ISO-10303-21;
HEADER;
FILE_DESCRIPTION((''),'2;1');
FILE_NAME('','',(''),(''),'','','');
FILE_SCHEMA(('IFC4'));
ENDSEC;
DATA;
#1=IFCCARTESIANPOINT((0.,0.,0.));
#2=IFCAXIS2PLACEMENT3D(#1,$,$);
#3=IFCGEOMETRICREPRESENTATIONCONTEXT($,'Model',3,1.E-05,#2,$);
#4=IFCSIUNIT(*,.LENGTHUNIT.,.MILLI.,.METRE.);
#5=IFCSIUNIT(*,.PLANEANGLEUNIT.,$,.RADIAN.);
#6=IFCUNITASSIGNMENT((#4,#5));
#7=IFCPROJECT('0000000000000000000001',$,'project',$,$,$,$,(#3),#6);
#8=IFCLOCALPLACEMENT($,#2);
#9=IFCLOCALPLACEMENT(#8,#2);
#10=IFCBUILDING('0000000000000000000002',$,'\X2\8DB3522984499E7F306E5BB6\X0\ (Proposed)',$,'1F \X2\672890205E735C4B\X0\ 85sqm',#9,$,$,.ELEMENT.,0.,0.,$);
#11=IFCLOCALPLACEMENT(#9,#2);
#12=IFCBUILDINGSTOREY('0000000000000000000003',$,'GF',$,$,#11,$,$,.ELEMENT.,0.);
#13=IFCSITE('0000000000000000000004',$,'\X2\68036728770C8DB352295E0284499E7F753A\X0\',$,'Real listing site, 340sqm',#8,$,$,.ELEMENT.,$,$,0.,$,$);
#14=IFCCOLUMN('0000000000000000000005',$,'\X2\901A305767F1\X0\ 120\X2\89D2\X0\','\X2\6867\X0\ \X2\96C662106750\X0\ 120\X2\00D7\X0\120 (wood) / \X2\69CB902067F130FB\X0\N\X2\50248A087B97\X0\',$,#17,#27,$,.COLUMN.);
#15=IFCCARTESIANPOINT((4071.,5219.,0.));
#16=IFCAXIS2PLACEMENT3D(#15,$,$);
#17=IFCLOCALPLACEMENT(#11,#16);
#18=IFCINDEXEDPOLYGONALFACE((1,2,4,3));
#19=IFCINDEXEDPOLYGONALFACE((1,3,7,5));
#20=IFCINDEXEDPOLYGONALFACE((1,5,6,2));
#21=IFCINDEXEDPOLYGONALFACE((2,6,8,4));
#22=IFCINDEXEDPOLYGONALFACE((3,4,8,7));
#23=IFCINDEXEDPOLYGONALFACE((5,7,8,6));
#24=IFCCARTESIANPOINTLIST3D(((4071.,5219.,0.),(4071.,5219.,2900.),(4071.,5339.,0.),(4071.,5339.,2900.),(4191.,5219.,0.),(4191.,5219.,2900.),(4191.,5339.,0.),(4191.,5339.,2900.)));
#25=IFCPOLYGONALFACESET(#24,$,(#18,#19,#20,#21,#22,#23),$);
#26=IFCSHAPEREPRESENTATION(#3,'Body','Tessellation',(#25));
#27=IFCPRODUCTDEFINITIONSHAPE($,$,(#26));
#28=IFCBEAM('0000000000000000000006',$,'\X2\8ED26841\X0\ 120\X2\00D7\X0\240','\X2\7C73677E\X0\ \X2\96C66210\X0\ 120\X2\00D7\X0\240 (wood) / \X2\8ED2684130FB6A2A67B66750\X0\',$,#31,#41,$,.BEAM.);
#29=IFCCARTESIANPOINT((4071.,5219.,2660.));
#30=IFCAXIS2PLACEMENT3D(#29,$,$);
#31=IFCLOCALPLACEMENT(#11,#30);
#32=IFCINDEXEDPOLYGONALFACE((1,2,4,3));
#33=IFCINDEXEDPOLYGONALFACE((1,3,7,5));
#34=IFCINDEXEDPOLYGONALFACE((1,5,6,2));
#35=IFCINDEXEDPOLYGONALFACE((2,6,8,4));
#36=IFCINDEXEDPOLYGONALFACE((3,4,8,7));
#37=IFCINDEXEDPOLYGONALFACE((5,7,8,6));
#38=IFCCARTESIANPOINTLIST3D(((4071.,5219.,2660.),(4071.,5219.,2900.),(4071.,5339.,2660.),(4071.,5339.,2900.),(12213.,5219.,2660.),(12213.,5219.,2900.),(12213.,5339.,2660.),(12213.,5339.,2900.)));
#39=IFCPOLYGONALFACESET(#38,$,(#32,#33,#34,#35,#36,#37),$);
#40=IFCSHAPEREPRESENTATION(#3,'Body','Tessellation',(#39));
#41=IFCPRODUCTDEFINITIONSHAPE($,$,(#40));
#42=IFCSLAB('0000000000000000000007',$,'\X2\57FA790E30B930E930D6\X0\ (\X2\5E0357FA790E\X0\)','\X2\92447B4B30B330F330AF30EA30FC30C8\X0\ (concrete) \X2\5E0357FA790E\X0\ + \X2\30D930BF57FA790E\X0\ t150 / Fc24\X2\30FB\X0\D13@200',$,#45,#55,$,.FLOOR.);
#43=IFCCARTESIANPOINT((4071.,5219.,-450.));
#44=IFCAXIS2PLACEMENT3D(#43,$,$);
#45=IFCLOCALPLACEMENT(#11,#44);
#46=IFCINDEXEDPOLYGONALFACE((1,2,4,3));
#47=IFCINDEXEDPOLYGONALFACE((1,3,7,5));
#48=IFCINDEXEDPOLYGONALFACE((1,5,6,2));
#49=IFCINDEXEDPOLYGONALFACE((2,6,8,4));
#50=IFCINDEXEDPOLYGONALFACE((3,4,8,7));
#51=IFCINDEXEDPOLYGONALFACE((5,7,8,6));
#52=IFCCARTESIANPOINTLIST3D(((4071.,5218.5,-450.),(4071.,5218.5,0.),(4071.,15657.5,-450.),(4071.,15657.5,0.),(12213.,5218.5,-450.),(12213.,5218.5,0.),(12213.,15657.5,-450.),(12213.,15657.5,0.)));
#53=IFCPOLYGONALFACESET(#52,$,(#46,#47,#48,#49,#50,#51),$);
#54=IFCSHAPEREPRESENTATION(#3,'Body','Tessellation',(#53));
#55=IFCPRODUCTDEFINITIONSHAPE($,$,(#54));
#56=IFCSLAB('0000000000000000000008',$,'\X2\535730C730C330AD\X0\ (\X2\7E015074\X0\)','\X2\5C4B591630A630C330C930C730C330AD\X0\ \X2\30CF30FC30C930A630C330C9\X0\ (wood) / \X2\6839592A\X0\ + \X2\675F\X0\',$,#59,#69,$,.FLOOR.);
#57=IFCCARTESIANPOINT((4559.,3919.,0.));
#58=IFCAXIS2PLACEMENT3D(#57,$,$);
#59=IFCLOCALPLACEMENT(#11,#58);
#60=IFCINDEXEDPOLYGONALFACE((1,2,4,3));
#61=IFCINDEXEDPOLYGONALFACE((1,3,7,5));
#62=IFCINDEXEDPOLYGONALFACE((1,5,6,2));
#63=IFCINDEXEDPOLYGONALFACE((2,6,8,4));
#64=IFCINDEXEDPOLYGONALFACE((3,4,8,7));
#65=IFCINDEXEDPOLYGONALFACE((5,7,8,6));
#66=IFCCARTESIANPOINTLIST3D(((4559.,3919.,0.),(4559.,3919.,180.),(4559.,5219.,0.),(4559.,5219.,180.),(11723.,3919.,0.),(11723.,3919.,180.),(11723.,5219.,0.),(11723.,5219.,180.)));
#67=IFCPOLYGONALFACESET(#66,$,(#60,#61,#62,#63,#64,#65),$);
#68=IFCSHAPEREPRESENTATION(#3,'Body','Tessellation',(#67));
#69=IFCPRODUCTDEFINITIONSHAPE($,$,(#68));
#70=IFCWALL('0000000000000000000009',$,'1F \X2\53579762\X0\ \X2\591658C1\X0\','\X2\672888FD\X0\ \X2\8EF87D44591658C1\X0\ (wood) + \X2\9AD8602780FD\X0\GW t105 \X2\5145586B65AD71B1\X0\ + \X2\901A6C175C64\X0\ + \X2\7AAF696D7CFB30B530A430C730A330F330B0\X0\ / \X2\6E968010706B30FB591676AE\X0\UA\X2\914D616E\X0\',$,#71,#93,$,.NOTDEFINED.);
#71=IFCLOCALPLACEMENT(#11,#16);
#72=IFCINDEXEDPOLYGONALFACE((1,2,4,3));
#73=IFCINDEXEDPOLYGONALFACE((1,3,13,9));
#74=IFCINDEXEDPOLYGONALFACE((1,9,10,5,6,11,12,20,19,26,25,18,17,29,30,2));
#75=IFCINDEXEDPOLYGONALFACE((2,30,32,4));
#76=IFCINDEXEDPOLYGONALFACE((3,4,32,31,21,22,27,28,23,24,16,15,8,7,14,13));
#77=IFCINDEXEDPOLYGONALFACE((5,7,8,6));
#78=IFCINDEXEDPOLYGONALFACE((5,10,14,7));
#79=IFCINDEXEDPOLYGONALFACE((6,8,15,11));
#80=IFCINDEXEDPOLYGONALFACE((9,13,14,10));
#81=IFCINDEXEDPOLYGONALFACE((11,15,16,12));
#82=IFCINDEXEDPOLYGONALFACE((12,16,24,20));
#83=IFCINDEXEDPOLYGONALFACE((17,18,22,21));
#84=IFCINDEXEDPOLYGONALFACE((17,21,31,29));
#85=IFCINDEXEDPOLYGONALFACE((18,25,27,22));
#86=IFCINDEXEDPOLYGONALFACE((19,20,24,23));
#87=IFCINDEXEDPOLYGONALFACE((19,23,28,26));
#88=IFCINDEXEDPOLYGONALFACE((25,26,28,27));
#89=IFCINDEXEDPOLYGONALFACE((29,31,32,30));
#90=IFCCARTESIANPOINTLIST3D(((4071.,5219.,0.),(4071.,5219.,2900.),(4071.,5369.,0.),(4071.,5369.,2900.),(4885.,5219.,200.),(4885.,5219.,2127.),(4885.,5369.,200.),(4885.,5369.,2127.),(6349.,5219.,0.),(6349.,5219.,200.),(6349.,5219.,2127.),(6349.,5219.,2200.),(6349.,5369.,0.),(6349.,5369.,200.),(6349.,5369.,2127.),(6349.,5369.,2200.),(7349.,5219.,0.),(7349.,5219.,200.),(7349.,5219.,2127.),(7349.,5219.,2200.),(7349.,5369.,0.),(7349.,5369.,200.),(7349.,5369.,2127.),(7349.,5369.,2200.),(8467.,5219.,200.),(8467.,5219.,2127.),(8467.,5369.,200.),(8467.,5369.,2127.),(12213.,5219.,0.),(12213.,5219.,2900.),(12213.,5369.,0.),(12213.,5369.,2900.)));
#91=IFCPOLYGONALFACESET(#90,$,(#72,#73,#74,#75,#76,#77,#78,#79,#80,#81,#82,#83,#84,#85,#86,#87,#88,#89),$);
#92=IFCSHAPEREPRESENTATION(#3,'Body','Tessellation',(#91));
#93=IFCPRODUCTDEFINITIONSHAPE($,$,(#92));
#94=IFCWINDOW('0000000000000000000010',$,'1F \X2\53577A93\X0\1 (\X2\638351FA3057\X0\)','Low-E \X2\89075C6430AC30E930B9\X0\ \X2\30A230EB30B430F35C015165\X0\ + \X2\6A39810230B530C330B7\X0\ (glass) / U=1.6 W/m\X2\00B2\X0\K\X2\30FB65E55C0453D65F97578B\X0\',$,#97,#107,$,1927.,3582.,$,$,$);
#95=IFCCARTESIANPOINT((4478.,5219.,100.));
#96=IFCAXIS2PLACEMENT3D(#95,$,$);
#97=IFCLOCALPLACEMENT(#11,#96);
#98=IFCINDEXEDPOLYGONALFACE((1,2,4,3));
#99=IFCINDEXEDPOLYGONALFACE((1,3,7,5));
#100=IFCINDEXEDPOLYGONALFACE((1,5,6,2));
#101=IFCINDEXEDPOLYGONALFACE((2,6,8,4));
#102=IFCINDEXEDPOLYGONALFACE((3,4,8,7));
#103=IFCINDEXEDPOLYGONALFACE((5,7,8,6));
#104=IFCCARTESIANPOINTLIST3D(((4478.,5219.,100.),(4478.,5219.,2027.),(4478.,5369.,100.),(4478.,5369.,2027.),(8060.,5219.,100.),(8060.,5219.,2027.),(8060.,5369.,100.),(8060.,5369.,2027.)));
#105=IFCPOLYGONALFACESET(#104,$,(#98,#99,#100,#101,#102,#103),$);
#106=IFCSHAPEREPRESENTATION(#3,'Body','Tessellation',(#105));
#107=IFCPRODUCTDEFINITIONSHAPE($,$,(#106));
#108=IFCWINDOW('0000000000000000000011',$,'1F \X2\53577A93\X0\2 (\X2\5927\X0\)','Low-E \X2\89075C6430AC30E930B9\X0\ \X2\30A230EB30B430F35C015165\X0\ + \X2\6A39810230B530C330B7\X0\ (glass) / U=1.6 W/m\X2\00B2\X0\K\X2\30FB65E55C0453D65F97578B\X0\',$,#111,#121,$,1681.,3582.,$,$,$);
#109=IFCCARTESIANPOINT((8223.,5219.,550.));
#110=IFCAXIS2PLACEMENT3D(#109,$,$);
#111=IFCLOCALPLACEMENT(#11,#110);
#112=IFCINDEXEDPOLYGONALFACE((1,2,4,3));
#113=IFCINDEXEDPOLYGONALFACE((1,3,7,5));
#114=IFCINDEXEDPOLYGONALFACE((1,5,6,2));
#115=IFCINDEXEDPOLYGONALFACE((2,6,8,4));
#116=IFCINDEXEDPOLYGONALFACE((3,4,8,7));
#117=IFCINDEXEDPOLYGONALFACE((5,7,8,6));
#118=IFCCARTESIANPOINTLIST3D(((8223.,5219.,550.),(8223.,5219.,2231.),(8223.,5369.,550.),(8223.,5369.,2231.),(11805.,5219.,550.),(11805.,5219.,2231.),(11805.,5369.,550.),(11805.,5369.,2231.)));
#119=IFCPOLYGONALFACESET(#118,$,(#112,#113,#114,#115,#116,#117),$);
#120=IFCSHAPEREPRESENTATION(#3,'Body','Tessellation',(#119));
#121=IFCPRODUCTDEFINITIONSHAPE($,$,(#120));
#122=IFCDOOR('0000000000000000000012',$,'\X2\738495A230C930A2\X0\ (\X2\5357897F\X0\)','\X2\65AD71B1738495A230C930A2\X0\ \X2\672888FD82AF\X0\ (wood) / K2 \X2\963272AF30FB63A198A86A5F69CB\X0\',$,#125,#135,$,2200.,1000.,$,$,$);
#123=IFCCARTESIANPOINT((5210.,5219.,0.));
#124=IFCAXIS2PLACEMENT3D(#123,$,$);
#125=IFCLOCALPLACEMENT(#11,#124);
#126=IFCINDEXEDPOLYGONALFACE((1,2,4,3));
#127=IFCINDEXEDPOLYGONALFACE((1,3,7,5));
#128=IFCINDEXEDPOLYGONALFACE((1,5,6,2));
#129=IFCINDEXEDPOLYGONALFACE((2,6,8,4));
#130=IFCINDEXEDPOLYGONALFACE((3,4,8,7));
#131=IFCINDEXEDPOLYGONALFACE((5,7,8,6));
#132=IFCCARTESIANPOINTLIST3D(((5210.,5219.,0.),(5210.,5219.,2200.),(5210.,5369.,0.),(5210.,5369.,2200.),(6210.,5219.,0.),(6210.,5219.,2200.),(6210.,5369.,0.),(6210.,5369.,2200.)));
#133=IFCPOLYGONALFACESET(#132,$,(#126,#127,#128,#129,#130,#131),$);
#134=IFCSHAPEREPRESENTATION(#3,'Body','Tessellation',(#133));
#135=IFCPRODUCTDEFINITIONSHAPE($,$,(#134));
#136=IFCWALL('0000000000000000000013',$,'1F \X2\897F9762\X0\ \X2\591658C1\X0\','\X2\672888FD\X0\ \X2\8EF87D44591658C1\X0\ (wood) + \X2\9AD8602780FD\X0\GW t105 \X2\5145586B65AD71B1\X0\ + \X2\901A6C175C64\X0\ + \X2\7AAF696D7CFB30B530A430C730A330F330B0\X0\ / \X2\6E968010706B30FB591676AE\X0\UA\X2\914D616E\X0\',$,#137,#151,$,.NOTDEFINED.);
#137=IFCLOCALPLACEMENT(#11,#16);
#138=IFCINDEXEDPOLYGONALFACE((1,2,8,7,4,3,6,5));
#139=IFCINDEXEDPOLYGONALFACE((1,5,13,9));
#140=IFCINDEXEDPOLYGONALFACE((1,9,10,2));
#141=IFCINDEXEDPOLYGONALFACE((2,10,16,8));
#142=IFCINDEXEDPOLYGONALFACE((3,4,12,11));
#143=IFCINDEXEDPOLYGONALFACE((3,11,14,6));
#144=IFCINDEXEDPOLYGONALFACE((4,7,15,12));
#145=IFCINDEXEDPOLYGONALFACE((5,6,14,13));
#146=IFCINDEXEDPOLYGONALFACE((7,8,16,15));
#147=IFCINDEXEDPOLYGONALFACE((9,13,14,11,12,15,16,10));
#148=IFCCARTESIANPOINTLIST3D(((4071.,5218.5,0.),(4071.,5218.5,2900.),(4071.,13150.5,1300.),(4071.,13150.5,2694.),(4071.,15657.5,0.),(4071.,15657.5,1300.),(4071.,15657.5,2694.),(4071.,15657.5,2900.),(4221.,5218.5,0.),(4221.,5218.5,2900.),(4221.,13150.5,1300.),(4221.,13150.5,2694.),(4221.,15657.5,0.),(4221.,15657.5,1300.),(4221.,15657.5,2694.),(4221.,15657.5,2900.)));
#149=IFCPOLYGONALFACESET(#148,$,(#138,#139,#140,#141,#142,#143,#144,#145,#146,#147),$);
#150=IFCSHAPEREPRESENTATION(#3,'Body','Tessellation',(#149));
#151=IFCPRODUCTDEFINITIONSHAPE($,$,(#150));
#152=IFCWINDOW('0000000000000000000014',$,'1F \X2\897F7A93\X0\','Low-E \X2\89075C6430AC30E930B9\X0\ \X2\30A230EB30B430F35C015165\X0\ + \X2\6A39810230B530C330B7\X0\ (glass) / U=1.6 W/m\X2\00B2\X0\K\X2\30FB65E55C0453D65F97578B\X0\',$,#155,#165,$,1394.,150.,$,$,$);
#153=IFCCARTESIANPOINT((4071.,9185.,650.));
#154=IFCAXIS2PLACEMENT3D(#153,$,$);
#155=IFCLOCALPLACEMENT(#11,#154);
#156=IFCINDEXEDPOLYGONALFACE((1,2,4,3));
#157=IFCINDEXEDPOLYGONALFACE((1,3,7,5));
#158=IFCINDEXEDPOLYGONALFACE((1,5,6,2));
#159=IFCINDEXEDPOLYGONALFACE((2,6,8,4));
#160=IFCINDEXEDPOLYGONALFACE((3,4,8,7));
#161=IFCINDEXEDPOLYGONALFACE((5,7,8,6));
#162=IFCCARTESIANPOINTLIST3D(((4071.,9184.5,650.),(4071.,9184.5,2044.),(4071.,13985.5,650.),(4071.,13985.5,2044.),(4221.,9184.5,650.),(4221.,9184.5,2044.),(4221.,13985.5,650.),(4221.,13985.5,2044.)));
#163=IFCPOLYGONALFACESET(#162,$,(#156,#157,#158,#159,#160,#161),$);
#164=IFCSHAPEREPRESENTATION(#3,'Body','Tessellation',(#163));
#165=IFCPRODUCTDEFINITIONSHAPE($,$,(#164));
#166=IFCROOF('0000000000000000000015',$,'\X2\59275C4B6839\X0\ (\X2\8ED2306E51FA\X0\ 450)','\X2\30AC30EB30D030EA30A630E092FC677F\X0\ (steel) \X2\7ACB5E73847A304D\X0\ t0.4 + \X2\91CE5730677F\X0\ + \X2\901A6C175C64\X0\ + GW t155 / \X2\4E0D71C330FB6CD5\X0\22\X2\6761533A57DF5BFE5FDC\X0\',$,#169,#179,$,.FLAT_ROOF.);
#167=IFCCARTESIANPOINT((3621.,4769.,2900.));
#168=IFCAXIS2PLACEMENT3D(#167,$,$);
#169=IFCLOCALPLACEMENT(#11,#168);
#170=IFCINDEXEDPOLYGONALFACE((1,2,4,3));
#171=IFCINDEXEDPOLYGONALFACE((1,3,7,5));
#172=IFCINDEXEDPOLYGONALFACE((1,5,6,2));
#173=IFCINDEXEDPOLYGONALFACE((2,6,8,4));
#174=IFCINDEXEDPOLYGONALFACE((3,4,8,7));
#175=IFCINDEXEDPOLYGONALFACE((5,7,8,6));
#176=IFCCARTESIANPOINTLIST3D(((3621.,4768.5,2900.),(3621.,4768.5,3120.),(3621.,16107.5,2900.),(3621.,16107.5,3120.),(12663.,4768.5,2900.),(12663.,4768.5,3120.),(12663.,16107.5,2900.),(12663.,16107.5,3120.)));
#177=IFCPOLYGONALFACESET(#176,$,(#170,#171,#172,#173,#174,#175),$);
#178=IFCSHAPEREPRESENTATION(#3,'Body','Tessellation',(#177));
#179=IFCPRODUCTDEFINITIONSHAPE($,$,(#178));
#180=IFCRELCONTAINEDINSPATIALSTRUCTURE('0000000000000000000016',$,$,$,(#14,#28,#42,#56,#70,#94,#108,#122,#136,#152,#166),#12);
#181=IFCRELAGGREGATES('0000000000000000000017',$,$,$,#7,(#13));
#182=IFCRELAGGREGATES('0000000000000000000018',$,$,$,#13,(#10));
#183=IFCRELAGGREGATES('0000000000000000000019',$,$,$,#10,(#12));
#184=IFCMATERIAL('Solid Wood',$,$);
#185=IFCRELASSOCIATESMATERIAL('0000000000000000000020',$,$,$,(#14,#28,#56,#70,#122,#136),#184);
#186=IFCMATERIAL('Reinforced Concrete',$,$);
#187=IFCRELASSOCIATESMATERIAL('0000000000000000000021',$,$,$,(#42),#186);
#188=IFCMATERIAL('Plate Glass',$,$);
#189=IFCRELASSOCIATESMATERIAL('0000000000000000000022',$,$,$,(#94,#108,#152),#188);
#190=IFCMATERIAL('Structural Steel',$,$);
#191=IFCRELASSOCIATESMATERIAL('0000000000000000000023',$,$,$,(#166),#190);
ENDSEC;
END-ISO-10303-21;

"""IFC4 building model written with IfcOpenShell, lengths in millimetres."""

from ifc_helpers import new_model, si_unit, frame, frame_2d, origin, place, context, project, spatial, rectangle, extrude, material, element, fill, save


model = new_model("IFC4")

# Units and contexts
model_context = context("Model", 3, precision=1e-05, world=origin())
ifc_project = project(units=[si_unit("LENGTHUNIT", "METRE", prefix="MILLI"), si_unit("PLANEANGLEUNIT", "RADIAN")], contexts=[model_context])

# Site, building, storey
site_placement = place(None, origin())
site = spatial("IfcSite", under=ifc_project, at=site_placement, Name="栃木県足利市葉鹿町", ObjectType="Real listing site, 340sqm", CompositionType="ELEMENT", RefElevation=0.0)
building_placement = place(site_placement, origin())
building = spatial("IfcBuilding", under=site, at=building_placement, Name="足利葉鹿の家 (Proposed)", ObjectType="1F 木造平屋 85sqm", CompositionType="ELEMENT", ElevationOfRefHeight=0.0, ElevationOfTerrain=0.0)
storey_placement = place(building_placement, origin())
storey = spatial("IfcBuildingStorey", under=building, at=storey_placement, Name="GF", CompositionType="ELEMENT", Elevation=0.0)

# Column
ifc_material_1 = material(Name="Solid Wood")
column_1_placement = place(storey_placement, frame((4071.0, 5219.0, 0.0)))
element("IfcColumn", 1, at=column_1_placement, inside=storey, material=ifc_material_1, Name="通し柱 120角", Description="桧 集成材 120×120 (wood) / 構造柱・N値計算", PredefinedType="COLUMN", context=model_context, shape_type="SweptSolid", body=[
    extrude(rectangle(XDim=120.0, YDim=120.0, at=frame_2d((60.0, 60.0))), frame((4071.0, 5219.0, 0.0)), (0.0, 0.0, 1.0), 2900.0),
])

# Beam
beam_1_placement = place(storey_placement, frame((4071.0, 5219.0, 2660.0)))
element("IfcBeam", 2, at=beam_1_placement, inside=storey, material=ifc_material_1, Name="軒桁 120×240", Description="米松 集成 120×240 (wood) / 軒桁・横架材", PredefinedType="BEAM", context=model_context, shape_type="SweptSolid", body=[
    extrude(rectangle(XDim=8142.0, YDim=120.0, at=frame_2d((4071.0, 60.0))), frame((4071.0, 5219.0, 2660.0)), (0.0, 0.0, 1.0), 240.0),
])

# Slabs
ifc_material_2 = material(Name="Reinforced Concrete")
slab_1_placement = place(storey_placement, frame((4071.0, 5219.0, -450.0)))
element("IfcSlab", 3, at=slab_1_placement, inside=storey, material=ifc_material_2, Name="基礎スラブ (布基礎)", Description="鉄筋コンクリート (concrete) 布基礎 + ベタ基礎 t150 / Fc24・D13@200", PredefinedType="FLOOR", context=model_context, shape_type="SweptSolid", body=[
    extrude(rectangle(XDim=8142.0, YDim=10439.0, at=frame_2d((4071.0, 5219.0))), frame((4071.0, 5219.0, -450.0)), (0.0, 0.0, 1.0), 450.0),
])
slab_2_placement = place(storey_placement, frame((4559.0, 3919.0, 0.0)))
element("IfcSlab", 4, at=slab_2_placement, inside=storey, material=ifc_material_1, Name="南デッキ (縁側)", Description="屋外ウッドデッキ ハードウッド (wood) / 根太 + 束", PredefinedType="FLOOR", context=model_context, shape_type="SweptSolid", body=[
    extrude(rectangle(XDim=7164.0, YDim=1300.0, at=frame_2d((3582.0, 650.0))), frame((4559.0, 3919.0, 0.0)), (0.0, 0.0, 1.0), 180.0),
])

# Wall, openings, windows, door
wall_1_placement = place(storey_placement, frame((4071.0, 5219.0, 0.0)))
wall_1 = element("IfcWall", 5, at=wall_1_placement, inside=storey, material=ifc_material_1, Name="1F 南面 外壁", Description="木製 軸組外壁 (wood) + 高性能GW t105 充填断熱 + 通気層 + 窯業系サイディング / 準耐火・外皮UA配慮", PredefinedType="NOTDEFINED", context=model_context, shape_type="SweptSolid", body=[
    extrude(rectangle(XDim=8142.0, YDim=150.0, at=frame_2d((4071.0, 75.0))), frame((4071.0, 5219.0, 0.0)), (0.0, 0.0, 1.0), 2900.0),
])
opening_1_placement = place(storey_placement, frame((4478.0, 5219.0, 100.0)))
opening_1 = element("IfcOpeningElement", 6, at=opening_1_placement, cuts=wall_1, PredefinedType="NOTDEFINED", context=model_context, shape_type="SweptSolid", body=[
    extrude(rectangle(XDim=3582.0, YDim=150.0, at=frame_2d((1791.0, 75.0))), frame((4478.0, 5219.0, 100.0)), (0.0, 0.0, 1.0), 1927.0),
])
opening_2_placement = place(storey_placement, frame((8223.0, 5219.0, 550.0)))
opening_2 = element("IfcOpeningElement", 7, at=opening_2_placement, cuts=wall_1, PredefinedType="NOTDEFINED", context=model_context, shape_type="SweptSolid", body=[
    extrude(rectangle(XDim=3582.0, YDim=150.0, at=frame_2d((1791.0, 75.0))), frame((8223.0, 5219.0, 550.0)), (0.0, 0.0, 1.0), 1681.0),
])
opening_3_placement = place(storey_placement, frame((5210.0, 5219.0, 0.0)))
opening_3 = element("IfcOpeningElement", 8, at=opening_3_placement, cuts=wall_1, PredefinedType="NOTDEFINED", context=model_context, shape_type="SweptSolid", body=[
    extrude(rectangle(XDim=1000.0, YDim=150.0, at=frame_2d((500.0, 75.0))), frame((5210.0, 5219.0, 0.0)), (0.0, 0.0, 1.0), 2200.0),
])
ifc_material_3 = material(Name="Plate Glass")
window_1_placement = place(storey_placement, frame((4478.0, 5219.0, 100.0)))
window_1 = element("IfcWindow", 9, at=window_1_placement, inside=storey, material=ifc_material_3, Name="1F 南窓1 (掃出し)", Description="Low-E 複層ガラス アルゴン封入 + 樹脂サッシ (glass) / U=1.6 W/m²K・日射取得型", OverallHeight=1927.0, OverallWidth=3582.0, context=model_context, shape_type="SweptSolid", body=[
    extrude(rectangle(XDim=3582.0, YDim=150.0, at=frame_2d((1791.0, 75.0))), frame((4478.0, 5219.0, 100.0)), (0.0, 0.0, 1.0), 1927.0),
])
fill(opening_1, window_1)
window_2_placement = place(storey_placement, frame((8223.0, 5219.0, 550.0)))
window_2 = element("IfcWindow", 10, at=window_2_placement, inside=storey, material=ifc_material_3, Name="1F 南窓2 (大)", Description="Low-E 複層ガラス アルゴン封入 + 樹脂サッシ (glass) / U=1.6 W/m²K・日射取得型", OverallHeight=1681.0, OverallWidth=3582.0, context=model_context, shape_type="SweptSolid", body=[
    extrude(rectangle(XDim=3582.0, YDim=150.0, at=frame_2d((1791.0, 75.0))), frame((8223.0, 5219.0, 550.0)), (0.0, 0.0, 1.0), 1681.0),
])
fill(opening_2, window_2)
door_placement = place(storey_placement, frame((5210.0, 5219.0, 0.0)))
door = element("IfcDoor", 11, at=door_placement, inside=storey, material=ifc_material_1, Name="玄関ドア (南西)", Description="断熱玄関ドア 木製芯 (wood) / K2 防犯・採風機構", OverallHeight=2200.0, OverallWidth=1000.0, context=model_context, shape_type="SweptSolid", body=[
    extrude(rectangle(XDim=1000.0, YDim=150.0, at=frame_2d((500.0, 75.0))), frame((5210.0, 5219.0, 0.0)), (0.0, 0.0, 1.0), 2200.0),
])
fill(opening_3, door)

# Wall, opening, window
wall_2_placement = place(storey_placement, frame((4071.0, 5219.0, 0.0)))
wall_2 = element("IfcWall", 12, at=wall_2_placement, inside=storey, material=ifc_material_1, Name="1F 西面 外壁", Description="木製 軸組外壁 (wood) + 高性能GW t105 充填断熱 + 通気層 + 窯業系サイディング / 準耐火・外皮UA配慮", PredefinedType="NOTDEFINED", context=model_context, shape_type="SweptSolid", body=[
    extrude(rectangle(XDim=150.0, YDim=10439.0, at=frame_2d((75.0, 5219.0))), frame((4071.0, 5219.0, 0.0)), (0.0, 0.0, 1.0), 2900.0),
])
opening_4_placement = place(storey_placement, frame((4071.0, 9185.0, 650.0)))
opening_4 = element("IfcOpeningElement", 13, at=opening_4_placement, cuts=wall_2, PredefinedType="NOTDEFINED", context=model_context, shape_type="SweptSolid", body=[
    extrude(rectangle(XDim=150.0, YDim=4801.0, at=frame_2d((75.0, 2400.0))), frame((4071.0, 9185.0, 650.0)), (0.0, 0.0, 1.0), 1394.0),
])
window_3_placement = place(storey_placement, frame((4071.0, 9185.0, 650.0)))
window_3 = element("IfcWindow", 14, at=window_3_placement, inside=storey, material=ifc_material_3, Name="1F 西窓", Description="Low-E 複層ガラス アルゴン封入 + 樹脂サッシ (glass) / U=1.6 W/m²K・日射取得型", OverallHeight=1394.0, OverallWidth=150.0, context=model_context, shape_type="SweptSolid", body=[
    extrude(rectangle(XDim=150.0, YDim=4801.0, at=frame_2d((75.0, 2400.0))), frame((4071.0, 9185.0, 650.0)), (0.0, 0.0, 1.0), 1394.0),
])
fill(opening_4, window_3)

# Roof
ifc_material_4 = material(Name="Structural Steel")
roof_placement = place(storey_placement, frame((3621.0, 4769.0, 2900.0)))
element("IfcRoof", 15, at=roof_placement, inside=storey, material=ifc_material_4, Name="大屋根 (軒の出 450)", Description="ガルバリウム鋼板 (steel) 立平葺き t0.4 + 野地板 + 通気層 + GW t155 / 不燃・法22条区域対応", PredefinedType="FLAT_ROOF", context=model_context, shape_type="SweptSolid", body=[
    extrude(rectangle(XDim=9042.0, YDim=11339.0, at=frame_2d((4521.0, 5669.0))), frame((3621.0, 4769.0, 2900.0)), (0.0, 0.0, 1.0), 220.0),
])

save(model, "model.ifc")
